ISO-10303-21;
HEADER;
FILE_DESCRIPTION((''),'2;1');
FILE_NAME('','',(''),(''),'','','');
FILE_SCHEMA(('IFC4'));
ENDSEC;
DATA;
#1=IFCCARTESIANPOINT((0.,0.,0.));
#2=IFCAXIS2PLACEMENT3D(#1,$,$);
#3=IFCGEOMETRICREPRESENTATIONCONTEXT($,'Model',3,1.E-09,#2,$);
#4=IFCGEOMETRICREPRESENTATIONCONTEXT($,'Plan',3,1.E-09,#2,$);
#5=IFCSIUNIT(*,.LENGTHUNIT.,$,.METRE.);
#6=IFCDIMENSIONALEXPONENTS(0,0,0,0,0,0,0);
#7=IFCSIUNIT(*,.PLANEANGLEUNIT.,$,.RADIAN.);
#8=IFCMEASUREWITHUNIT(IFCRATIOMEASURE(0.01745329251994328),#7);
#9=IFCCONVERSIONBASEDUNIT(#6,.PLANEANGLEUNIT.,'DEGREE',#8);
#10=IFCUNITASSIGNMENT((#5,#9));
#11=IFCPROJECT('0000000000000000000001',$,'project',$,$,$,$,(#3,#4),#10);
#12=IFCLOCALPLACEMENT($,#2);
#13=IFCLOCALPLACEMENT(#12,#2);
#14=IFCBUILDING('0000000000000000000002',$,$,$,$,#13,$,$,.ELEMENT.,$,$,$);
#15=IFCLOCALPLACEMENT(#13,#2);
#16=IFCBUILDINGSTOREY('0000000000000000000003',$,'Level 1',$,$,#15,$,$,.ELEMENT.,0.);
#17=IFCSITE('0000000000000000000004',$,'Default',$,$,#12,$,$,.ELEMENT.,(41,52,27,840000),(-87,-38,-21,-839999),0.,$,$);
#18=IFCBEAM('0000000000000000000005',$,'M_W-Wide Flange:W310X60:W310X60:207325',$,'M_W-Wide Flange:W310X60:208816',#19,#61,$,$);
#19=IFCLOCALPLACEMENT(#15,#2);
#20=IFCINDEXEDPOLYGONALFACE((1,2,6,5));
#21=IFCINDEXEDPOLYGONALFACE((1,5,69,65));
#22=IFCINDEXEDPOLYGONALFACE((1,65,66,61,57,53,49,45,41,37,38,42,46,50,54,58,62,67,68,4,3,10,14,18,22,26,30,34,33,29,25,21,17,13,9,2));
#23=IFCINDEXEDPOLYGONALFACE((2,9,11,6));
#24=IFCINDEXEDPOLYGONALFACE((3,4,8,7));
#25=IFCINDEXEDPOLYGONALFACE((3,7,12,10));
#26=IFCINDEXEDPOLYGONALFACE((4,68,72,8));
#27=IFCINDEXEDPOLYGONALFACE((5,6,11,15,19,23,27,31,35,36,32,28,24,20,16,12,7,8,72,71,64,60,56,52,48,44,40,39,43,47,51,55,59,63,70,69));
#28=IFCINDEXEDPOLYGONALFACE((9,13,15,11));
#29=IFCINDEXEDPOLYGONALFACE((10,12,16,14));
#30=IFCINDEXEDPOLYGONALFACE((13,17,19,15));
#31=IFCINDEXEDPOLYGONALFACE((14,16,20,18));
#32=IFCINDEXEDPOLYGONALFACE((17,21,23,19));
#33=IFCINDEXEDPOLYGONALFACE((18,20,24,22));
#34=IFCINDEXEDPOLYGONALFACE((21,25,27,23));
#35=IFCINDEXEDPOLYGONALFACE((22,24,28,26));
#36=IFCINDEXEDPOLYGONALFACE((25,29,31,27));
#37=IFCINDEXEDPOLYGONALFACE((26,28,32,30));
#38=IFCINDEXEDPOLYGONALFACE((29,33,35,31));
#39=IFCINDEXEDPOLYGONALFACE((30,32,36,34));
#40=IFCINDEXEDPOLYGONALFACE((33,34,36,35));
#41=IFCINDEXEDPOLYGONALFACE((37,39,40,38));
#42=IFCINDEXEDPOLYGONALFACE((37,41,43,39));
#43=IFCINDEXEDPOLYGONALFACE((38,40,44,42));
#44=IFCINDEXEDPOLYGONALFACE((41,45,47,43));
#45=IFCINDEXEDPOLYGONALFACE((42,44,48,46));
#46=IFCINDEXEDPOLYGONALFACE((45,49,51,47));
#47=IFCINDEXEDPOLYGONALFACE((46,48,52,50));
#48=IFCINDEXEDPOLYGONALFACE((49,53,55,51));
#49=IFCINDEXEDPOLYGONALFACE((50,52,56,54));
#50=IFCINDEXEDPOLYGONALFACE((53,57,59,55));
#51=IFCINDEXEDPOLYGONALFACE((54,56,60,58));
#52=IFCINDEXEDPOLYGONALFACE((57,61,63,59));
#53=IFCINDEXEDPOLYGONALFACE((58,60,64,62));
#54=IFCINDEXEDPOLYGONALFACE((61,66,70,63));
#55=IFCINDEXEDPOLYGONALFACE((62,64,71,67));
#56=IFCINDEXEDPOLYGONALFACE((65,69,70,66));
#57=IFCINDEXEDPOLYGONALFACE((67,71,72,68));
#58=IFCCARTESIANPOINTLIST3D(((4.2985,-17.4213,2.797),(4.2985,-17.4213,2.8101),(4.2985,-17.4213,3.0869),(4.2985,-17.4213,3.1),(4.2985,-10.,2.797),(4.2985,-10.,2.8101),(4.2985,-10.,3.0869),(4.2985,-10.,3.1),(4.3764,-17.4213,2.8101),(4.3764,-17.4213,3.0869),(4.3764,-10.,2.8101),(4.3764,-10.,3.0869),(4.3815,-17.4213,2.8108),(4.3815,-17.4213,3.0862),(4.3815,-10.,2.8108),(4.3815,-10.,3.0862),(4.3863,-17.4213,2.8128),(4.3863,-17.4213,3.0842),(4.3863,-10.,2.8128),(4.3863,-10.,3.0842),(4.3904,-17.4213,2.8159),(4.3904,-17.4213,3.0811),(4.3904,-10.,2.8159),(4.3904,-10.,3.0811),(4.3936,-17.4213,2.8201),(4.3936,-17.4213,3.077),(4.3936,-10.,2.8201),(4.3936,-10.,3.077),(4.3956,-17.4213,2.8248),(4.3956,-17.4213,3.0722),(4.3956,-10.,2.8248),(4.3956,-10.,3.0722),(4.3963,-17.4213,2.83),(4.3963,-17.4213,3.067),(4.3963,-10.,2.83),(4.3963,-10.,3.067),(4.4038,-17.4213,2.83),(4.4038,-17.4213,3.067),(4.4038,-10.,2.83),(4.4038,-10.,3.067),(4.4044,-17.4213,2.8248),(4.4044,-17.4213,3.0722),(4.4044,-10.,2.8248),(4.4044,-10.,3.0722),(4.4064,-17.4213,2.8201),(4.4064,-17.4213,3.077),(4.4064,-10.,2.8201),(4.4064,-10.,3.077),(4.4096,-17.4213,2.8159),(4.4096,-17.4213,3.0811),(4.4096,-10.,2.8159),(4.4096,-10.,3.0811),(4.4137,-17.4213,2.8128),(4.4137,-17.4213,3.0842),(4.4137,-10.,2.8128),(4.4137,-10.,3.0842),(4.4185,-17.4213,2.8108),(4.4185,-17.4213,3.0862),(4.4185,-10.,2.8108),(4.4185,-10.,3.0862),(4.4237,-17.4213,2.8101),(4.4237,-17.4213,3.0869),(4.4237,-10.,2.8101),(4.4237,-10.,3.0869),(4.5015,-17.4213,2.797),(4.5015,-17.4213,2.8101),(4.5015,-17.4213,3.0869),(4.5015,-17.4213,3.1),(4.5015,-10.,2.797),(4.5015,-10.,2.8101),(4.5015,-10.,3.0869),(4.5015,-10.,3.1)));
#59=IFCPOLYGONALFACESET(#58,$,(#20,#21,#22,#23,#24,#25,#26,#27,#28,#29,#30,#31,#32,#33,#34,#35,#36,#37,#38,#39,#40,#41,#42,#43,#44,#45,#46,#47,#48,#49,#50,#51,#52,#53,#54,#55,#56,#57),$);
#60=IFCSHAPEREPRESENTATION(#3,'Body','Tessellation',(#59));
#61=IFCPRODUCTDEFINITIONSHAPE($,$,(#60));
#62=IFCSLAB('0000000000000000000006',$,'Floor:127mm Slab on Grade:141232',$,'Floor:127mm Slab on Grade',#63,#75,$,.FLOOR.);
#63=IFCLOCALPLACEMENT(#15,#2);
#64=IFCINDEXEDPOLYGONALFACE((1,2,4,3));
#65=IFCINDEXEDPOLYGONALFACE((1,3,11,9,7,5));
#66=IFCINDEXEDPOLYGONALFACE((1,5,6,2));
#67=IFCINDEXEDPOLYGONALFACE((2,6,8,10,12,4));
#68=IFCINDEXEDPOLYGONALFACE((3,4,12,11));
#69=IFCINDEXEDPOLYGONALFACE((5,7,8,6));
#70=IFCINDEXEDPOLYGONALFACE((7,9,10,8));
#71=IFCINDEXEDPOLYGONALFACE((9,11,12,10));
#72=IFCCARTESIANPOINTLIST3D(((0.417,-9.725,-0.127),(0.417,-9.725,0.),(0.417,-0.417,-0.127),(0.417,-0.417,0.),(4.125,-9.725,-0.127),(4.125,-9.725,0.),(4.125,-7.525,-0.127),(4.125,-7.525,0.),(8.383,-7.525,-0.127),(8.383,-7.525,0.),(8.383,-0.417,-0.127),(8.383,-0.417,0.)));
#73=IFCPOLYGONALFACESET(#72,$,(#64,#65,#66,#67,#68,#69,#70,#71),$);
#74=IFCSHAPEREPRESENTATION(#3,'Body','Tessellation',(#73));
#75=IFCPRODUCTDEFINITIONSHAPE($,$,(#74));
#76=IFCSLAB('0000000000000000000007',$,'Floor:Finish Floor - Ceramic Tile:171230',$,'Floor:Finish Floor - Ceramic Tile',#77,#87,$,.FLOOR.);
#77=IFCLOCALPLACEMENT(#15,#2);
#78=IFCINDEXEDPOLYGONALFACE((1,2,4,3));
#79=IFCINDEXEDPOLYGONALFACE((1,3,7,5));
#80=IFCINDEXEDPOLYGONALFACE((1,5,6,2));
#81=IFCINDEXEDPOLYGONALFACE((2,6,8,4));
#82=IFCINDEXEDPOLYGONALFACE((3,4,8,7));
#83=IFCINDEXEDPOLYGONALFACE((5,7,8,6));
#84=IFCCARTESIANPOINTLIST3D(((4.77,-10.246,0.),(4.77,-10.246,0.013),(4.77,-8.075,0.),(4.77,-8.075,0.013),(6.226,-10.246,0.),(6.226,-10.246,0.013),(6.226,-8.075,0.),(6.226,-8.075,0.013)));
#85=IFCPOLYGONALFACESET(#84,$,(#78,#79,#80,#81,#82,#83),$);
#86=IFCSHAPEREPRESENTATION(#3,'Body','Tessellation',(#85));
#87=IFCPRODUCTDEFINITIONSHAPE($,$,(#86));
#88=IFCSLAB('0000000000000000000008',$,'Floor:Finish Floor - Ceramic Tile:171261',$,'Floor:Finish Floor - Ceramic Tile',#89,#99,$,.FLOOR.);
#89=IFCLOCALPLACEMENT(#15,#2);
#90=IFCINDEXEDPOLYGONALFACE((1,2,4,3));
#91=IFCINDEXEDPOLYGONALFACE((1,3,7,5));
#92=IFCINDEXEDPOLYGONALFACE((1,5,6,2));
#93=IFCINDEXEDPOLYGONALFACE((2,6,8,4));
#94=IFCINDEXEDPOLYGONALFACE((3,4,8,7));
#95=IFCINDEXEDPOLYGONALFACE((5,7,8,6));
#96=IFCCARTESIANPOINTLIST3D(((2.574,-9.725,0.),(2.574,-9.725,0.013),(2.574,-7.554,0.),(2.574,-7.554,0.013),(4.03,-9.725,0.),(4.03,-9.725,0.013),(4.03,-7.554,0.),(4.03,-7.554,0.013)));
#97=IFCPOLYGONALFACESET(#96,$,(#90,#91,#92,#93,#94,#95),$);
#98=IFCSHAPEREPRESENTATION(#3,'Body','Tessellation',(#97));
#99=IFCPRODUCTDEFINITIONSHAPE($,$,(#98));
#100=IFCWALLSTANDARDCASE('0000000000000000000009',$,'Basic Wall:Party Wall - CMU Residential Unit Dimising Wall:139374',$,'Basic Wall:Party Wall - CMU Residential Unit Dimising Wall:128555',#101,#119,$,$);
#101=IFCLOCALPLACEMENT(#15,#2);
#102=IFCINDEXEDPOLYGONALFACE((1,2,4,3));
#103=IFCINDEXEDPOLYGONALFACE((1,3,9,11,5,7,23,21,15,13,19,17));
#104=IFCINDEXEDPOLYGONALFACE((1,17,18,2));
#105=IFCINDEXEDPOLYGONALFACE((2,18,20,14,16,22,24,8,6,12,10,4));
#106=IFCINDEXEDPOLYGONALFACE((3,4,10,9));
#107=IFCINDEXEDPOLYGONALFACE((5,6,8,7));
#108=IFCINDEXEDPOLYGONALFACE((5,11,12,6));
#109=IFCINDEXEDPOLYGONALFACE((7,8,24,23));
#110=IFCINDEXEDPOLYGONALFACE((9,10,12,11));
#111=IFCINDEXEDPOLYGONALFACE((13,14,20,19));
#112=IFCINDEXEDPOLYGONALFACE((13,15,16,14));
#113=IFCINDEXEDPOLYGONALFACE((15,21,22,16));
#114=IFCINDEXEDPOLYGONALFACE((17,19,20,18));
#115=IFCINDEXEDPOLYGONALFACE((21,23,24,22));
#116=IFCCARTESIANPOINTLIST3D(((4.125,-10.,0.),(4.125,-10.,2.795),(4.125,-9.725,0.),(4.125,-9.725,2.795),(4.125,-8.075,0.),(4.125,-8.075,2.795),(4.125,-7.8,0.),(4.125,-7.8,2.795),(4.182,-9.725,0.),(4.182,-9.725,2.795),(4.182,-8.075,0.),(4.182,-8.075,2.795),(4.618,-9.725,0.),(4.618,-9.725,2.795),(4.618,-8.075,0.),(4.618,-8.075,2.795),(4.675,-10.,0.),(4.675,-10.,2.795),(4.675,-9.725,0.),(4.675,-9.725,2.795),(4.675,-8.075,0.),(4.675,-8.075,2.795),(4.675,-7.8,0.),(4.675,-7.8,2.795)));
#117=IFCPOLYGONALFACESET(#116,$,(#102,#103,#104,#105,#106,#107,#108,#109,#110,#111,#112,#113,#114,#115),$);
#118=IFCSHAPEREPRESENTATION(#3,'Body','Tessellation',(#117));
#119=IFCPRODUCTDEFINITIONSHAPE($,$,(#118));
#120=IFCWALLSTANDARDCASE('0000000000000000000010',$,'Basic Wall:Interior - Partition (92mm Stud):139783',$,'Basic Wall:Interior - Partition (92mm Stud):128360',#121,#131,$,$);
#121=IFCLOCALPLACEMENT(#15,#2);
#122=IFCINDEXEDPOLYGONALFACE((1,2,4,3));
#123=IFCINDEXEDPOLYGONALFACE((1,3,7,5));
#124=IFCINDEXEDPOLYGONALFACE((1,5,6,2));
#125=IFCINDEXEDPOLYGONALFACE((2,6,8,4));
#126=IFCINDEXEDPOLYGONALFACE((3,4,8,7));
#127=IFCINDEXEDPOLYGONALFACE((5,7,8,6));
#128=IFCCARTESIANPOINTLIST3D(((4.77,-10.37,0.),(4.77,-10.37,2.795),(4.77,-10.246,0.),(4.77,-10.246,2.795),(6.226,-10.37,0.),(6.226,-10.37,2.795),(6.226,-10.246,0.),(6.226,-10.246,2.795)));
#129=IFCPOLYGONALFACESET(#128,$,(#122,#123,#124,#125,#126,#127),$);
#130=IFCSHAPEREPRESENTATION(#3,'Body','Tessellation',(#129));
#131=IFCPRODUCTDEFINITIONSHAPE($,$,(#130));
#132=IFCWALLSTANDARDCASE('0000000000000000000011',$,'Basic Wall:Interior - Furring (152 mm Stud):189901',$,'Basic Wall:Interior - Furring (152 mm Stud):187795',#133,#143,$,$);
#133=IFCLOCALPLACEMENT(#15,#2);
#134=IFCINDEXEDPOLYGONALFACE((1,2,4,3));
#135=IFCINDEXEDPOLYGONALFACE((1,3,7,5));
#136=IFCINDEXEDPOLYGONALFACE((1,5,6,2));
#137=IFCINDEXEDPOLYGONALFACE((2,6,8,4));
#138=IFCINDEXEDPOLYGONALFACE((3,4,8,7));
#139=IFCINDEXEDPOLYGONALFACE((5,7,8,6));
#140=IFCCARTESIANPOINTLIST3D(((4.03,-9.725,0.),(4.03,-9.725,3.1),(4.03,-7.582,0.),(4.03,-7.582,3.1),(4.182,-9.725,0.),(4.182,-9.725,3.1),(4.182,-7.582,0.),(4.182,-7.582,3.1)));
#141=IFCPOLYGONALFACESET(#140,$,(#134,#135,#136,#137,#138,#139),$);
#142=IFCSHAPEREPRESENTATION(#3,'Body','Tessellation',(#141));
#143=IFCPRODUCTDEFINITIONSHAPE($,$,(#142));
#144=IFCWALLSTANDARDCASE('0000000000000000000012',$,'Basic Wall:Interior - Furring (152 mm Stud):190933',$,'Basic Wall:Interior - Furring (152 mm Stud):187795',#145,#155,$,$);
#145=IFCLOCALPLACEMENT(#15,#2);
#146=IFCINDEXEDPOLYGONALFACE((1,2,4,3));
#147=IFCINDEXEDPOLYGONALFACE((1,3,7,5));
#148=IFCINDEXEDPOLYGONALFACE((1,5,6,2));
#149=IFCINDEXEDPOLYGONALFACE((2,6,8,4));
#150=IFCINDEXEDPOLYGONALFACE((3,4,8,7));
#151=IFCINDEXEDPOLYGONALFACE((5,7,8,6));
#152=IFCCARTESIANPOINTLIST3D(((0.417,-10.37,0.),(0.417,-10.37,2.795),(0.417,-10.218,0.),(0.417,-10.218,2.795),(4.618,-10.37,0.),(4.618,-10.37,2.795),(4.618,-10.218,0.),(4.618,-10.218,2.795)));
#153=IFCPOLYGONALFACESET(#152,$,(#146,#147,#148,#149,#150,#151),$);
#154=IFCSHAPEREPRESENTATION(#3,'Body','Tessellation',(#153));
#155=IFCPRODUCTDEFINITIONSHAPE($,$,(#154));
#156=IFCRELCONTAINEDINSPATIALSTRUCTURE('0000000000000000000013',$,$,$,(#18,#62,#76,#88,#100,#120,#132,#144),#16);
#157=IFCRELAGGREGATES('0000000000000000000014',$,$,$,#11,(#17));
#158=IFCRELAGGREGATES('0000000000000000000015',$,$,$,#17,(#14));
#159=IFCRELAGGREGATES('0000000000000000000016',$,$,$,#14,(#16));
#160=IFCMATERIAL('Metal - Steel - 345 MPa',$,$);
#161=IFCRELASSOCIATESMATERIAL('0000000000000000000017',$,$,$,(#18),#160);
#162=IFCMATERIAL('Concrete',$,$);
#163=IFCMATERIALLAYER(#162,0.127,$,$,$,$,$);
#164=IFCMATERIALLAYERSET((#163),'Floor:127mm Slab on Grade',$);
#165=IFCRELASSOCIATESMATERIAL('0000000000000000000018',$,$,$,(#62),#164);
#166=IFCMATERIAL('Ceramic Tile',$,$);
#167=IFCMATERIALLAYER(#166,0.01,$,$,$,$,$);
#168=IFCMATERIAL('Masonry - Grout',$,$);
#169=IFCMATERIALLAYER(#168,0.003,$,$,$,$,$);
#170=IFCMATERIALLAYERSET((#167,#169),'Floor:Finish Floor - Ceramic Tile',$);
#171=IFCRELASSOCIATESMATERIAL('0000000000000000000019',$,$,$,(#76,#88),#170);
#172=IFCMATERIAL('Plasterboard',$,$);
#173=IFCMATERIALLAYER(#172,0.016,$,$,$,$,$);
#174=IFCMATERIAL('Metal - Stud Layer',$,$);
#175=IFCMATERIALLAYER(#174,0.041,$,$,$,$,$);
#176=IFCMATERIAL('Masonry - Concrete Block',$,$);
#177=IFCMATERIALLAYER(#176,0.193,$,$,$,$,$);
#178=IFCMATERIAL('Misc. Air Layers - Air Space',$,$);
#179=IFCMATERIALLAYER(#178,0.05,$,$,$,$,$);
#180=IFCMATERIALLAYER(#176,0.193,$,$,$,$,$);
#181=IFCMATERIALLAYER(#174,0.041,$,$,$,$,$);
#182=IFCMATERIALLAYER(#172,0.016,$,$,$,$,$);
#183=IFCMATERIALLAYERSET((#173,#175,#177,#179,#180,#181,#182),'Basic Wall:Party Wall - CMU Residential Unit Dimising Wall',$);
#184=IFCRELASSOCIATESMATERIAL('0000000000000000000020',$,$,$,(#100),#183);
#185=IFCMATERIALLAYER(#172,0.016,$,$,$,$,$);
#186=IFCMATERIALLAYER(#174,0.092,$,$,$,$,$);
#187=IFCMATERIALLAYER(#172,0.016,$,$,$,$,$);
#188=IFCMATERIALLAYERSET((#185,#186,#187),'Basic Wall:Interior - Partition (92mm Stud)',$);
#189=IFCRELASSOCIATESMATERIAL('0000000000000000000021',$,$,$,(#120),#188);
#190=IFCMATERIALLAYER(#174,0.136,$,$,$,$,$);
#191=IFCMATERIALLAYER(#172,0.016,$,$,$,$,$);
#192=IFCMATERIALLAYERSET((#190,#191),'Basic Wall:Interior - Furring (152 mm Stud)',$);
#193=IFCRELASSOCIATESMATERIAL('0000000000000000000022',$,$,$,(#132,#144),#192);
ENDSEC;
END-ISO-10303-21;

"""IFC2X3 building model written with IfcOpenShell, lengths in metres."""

from ifc_helpers import new_model, entity, si_unit, converted_unit, frame, frame_2d, origin, place, context, project, spatial, polyline, circle_curve, parameter, trimmed, segment, composite_curve, rectangle, outline, extrude, clip, bounded_halfspace, material, layer, layer_set, layer_usage, element, save


model = new_model("IFC2X3")

# Units and contexts
model_context = context("Model", 3, precision=1e-09, world=origin())
plan_context = context("Plan", 3, precision=1e-09, world=origin())
ifc_project = project(units=[si_unit("LENGTHUNIT", "METRE"), converted_unit("PLANEANGLEUNIT", "DEGREE", entity("IfcRatioMeasure", 0.01745329251994328), si_unit("PLANEANGLEUNIT", "RADIAN"), dimensions=[0, 0, 0, 0, 0, 0, 0])], contexts=[model_context, plan_context])

# Site, building, storey
site_placement = place(None, origin())
site = spatial("IfcSite", under=ifc_project, at=site_placement, Name="Default", CompositionType="ELEMENT", RefLatitude=(41, 52, 27, 840000), RefLongitude=(-87, -38, -21, -839999), RefElevation=0.0)
building_placement = place(site_placement, origin())
building = spatial("IfcBuilding", under=site, at=building_placement, CompositionType="ELEMENT")
storey_placement = place(building_placement, origin())
storey = spatial("IfcBuildingStorey", under=building, at=storey_placement, Name="Level 1", CompositionType="ELEMENT", Elevation=0.0)

# Beam
ifc_material_1 = material(Name="Metal - Steel - 345 MPa")
beam_placement = place(storey_placement, frame((4.4, -10.0, 3.1), z_axis=(0.0, 0.0, 1.0), x_axis=(-1.0, 0.0, 0.0)))
element("IfcBeam", 1, at=beam_placement, inside=storey, material=ifc_material_1, Name="M_W-Wide Flange:W310X60:W310X60:207325", ObjectType="M_W-Wide Flange:W310X60:208816", context=model_context, shape_type="SweptSolid", body=[
    extrude(outline(composite_curve([segment(polyline([(0.1384, -0.1015), (0.1515, -0.1015)]), True, "CONTINUOUS"), segment(polyline([(0.1515, -0.1015), (0.1515, 0.1015)]), True, "CONTINUOUS"), segment(polyline([(0.1515, 0.1015), (0.1384, 0.1015)]), True, "CONTINUOUS"), segment(polyline([(0.1384, 0.1015), (0.1384, 0.0236)]), True, "CONTINUOUS"), segment(trimmed(circle_curve(frame_2d((0.1185, 0.0236), x_axis=(0.0, 1.0)), 0.0199), [parameter(180.0)], [parameter(270.0)], True, "PARAMETER"), False, "CONTINUOUS"), segment(polyline([(0.1185, 0.0037), (-0.1185, 0.0037)]), True, "CONTINUOUS"), segment(trimmed(circle_curve(frame_2d((-0.1185, 0.0236), x_axis=(0.0, 1.0)), 0.0199), [parameter(90.0)], [parameter(180.0)], True, "PARAMETER"), False, "CONTINUOUS"), segment(polyline([(-0.1384, 0.0236), (-0.1384, 0.1015)]), True, "CONTINUOUS"), segment(polyline([(-0.1384, 0.1015), (-0.1515, 0.1015)]), True, "CONTINUOUS"), segment(polyline([(-0.1515, 0.1015), (-0.1515, -0.1015)]), True, "CONTINUOUS"), segment(polyline([(-0.1515, -0.1015), (-0.1384, -0.1015)]), True, "CONTINUOUS"), segment(polyline([(-0.1384, -0.1015), (-0.1384, -0.0237)]), True, "CONTINUOUS"), segment(trimmed(circle_curve(frame_2d((-0.1185, -0.0237), x_axis=(0.0, 1.0)), 0.0199), [parameter(360.0)], [parameter(90.0)], True, "PARAMETER"), False, "CONTINUOUS"), segment(polyline([(-0.1185, -0.0038), (0.1185, -0.0038)]), True, "CONTINUOUS"), segment(trimmed(circle_curve(frame_2d((0.1185, -0.0237), x_axis=(0.0, 1.0)), 0.0199), [parameter(270.0)], [parameter(0.0)], True, "PARAMETER"), False, "CONTINUOUS"), segment(polyline([(0.1384, -0.0237), (0.1384, -0.1015)]), True, "CONTINUOUS")], self_intersect=False)), frame((0.0, 7.4213, -0.1515), z_axis=(0.0, -1.0, 0.0), x_axis=(0.0, 0.0, -1.0)), (0.0, 0.0, 1.0), 7.4213),
])

# Slabs
ifc_material_2 = material(Name="Concrete")
ifc_layer_1 = layer(ifc_material_2, 0.127)
ifc_layer_set_1 = layer_set([ifc_layer_1], Name="Floor:127mm Slab on Grade")
ifc_layer_usage_1 = layer_usage(ifc_layer_set_1, "AXIS3", "POSITIVE", 0.0)
slab_1_placement = place(storey_placement, frame((0.417, -9.725, -0.127)))
element("IfcSlab", 2, at=slab_1_placement, inside=storey, material=ifc_layer_usage_1, Name="Floor:127mm Slab on Grade:141232", ObjectType="Floor:127mm Slab on Grade", PredefinedType="FLOOR", context=model_context, shape_type="SweptSolid", body=[
    extrude(outline(polyline([(-3.983, 4.654), (-3.983, -2.454), (0.275, -2.454), (0.275, -4.654), (3.983, -4.654), (3.983, 4.654), (-3.983, 4.654)])), frame((3.983, 4.654, 0.127), z_axis=(0.0, 0.0, -1.0), x_axis=(-1.0, 0.0, 0.0)), (0.0, 0.0, 1.0), 0.127),
])
ifc_material_3 = material(Name="Ceramic Tile")
ifc_layer_2 = layer(ifc_material_3, 0.01)
ifc_material_4 = material(Name="Masonry - Grout")
ifc_layer_3 = layer(ifc_material_4, 0.003)
ifc_layer_set_2 = layer_set([ifc_layer_2, ifc_layer_3], Name="Floor:Finish Floor - Ceramic Tile")
ifc_layer_usage_2 = layer_usage(ifc_layer_set_2, "AXIS3", "POSITIVE", 0.0)
slab_2_placement = place(storey_placement, frame((4.77, -10.246, 0.0)))
element("IfcSlab", 3, at=slab_2_placement, inside=storey, material=ifc_layer_usage_2, Name="Floor:Finish Floor - Ceramic Tile:171230", ObjectType="Floor:Finish Floor - Ceramic Tile", PredefinedType="FLOOR", context=model_context, shape_type="SweptSolid", body=[
    extrude(rectangle(XDim=1.456, YDim=2.171, at=frame_2d((0.0, 0.0), x_axis=(-1.0, 0.0))), frame((0.728, 1.0855, 0.013), z_axis=(0.0, 0.0, -1.0), x_axis=(-1.0, 0.0, 0.0)), (0.0, 0.0, 1.0), 0.013),
])
ifc_layer_usage_3 = layer_usage(ifc_layer_set_2, "AXIS3", "POSITIVE", 0.0)
slab_3_placement = place(storey_placement, frame((2.574, -9.725, 0.0)))
element("IfcSlab", 4, at=slab_3_placement, inside=storey, material=ifc_layer_usage_3, Name="Floor:Finish Floor - Ceramic Tile:171261", ObjectType="Floor:Finish Floor - Ceramic Tile", PredefinedType="FLOOR", context=model_context, shape_type="SweptSolid", body=[
    extrude(rectangle(XDim=2.171, YDim=1.456, at=frame_2d((0.0, 0.0), x_axis=(0.0, -1.0))), frame((0.728, 1.0855, 0.013), z_axis=(0.0, 0.0, -1.0), x_axis=(-1.0, 0.0, 0.0)), (0.0, 0.0, 1.0), 0.013),
])

# Walls
ifc_material_5 = material(Name="Plasterboard")
ifc_layer_4 = layer(ifc_material_5, 0.016)
ifc_material_6 = material(Name="Metal - Stud Layer")
ifc_layer_5 = layer(ifc_material_6, 0.041)
ifc_material_7 = material(Name="Masonry - Concrete Block")
ifc_layer_6 = layer(ifc_material_7, 0.193)
ifc_material_8 = material(Name="Misc. Air Layers - Air Space")
ifc_layer_7 = layer(ifc_material_8, 0.05)
ifc_layer_8 = layer(ifc_material_7, 0.193)
ifc_layer_9 = layer(ifc_material_6, 0.041)
ifc_layer_10 = layer(ifc_material_5, 0.016)
ifc_layer_set_3 = layer_set([ifc_layer_4, ifc_layer_5, ifc_layer_6, ifc_layer_7, ifc_layer_8, ifc_layer_9, ifc_layer_10], Name="Basic Wall:Party Wall - CMU Residential Unit Dimising Wall")
ifc_layer_usage_4 = layer_usage(ifc_layer_set_3, "AXIS2", "NEGATIVE", 0.275)
wall_1_placement = place(storey_placement, frame((4.4, -10.0, 0.0), z_axis=(0.0, 0.0, 1.0), x_axis=(0.0, 1.0, 0.0)))
element("IfcWallStandardCase", 5, at=wall_1_placement, inside=storey, material=ifc_layer_usage_4, Name="Basic Wall:Party Wall - CMU Residential Unit Dimising Wall:139374", ObjectType="Basic Wall:Party Wall - CMU Residential Unit Dimising Wall:128555", context=model_context, shape_type="Clipping", body=[
    clip(clip(extrude(rectangle(XDim=2.2, YDim=0.55, at=frame_2d((1.1, 0.0), x_axis=(-1.0, 0.0))), origin(), (0.0, 0.0, 1.0), 2.795), bounded_halfspace(frame((1.925, 0.218, 0.0), z_axis=(0.0, -1.0, 0.0), x_axis=(1.0, 0.0, 0.0)), True, frame((1.925, 0.218, 0.0), z_axis=(0.0, -1.0, 0.0), x_axis=(1.0, 0.0, 0.0)), polyline([(0.0, 0.0), (0.0, 2.795), (-1.65, 2.795), (-1.65, 0.0), (0.0, 0.0)]))), bounded_halfspace(frame((0.275, -0.218, 0.0), z_axis=(0.0, 1.0, 0.0), x_axis=(-1.0, 0.0, 0.0)), True, frame((0.275, -0.218, 0.0), z_axis=(0.0, 1.0, 0.0), x_axis=(-1.0, 0.0, 0.0)), polyline([(0.0, 0.0), (0.0, 2.795), (-1.65, 2.795), (-1.65, 0.0), (0.0, 0.0)]))),
])
ifc_layer_11 = layer(ifc_material_5, 0.016)
ifc_layer_12 = layer(ifc_material_6, 0.092)
ifc_layer_13 = layer(ifc_material_5, 0.016)
ifc_layer_set_4 = layer_set([ifc_layer_11, ifc_layer_12, ifc_layer_13], Name="Basic Wall:Interior - Partition (92mm Stud)")
ifc_layer_usage_5 = layer_usage(ifc_layer_set_4, "AXIS2", "NEGATIVE", 0.062)
wall_2_placement = place(storey_placement, frame((4.77, -10.308, 0.0)))
element("IfcWallStandardCase", 6, at=wall_2_placement, inside=storey, material=ifc_layer_usage_5, Name="Basic Wall:Interior - Partition (92mm Stud):139783", ObjectType="Basic Wall:Interior - Partition (92mm Stud):128360", context=model_context, shape_type="SweptSolid", body=[
    extrude(rectangle(XDim=1.456, YDim=0.124, at=frame_2d((0.728, 0.0), x_axis=(-1.0, 0.0))), origin(), (0.0, 0.0, 1.0), 2.795),
])
ifc_layer_14 = layer(ifc_material_6, 0.136)
ifc_layer_15 = layer(ifc_material_5, 0.016)
ifc_layer_set_5 = layer_set([ifc_layer_14, ifc_layer_15], Name="Basic Wall:Interior - Furring (152 mm Stud)")
ifc_layer_usage_6 = layer_usage(ifc_layer_set_5, "AXIS2", "POSITIVE", -0.076)
wall_3_placement = place(storey_placement, frame((4.106, -9.725, 0.0), z_axis=(0.0, 0.0, 1.0), x_axis=(0.0, 1.0, 0.0)))
element("IfcWallStandardCase", 7, at=wall_3_placement, inside=storey, material=ifc_layer_usage_6, Name="Basic Wall:Interior - Furring (152 mm Stud):189901", ObjectType="Basic Wall:Interior - Furring (152 mm Stud):187795", context=model_context, shape_type="SweptSolid", body=[
    extrude(rectangle(XDim=2.143, YDim=0.152, at=frame_2d((1.0715, 0.0), x_axis=(-1.0, 0.0))), origin(), (0.0, 0.0, 1.0), 3.1),
])
ifc_layer_usage_7 = layer_usage(ifc_layer_set_5, "AXIS2", "NEGATIVE", 0.076)
wall_4_placement = place(storey_placement, frame((0.417, -10.294, 0.0)))
element("IfcWallStandardCase", 8, at=wall_4_placement, inside=storey, material=ifc_layer_usage_7, Name="Basic Wall:Interior - Furring (152 mm Stud):190933", ObjectType="Basic Wall:Interior - Furring (152 mm Stud):187795", context=model_context, shape_type="SweptSolid", body=[
    extrude(rectangle(XDim=4.201, YDim=0.152, at=frame_2d((2.1005, 0.0), x_axis=(-1.0, 0.0))), origin(), (0.0, 0.0, 1.0), 2.795),
])

save(model, "model.ifc")
